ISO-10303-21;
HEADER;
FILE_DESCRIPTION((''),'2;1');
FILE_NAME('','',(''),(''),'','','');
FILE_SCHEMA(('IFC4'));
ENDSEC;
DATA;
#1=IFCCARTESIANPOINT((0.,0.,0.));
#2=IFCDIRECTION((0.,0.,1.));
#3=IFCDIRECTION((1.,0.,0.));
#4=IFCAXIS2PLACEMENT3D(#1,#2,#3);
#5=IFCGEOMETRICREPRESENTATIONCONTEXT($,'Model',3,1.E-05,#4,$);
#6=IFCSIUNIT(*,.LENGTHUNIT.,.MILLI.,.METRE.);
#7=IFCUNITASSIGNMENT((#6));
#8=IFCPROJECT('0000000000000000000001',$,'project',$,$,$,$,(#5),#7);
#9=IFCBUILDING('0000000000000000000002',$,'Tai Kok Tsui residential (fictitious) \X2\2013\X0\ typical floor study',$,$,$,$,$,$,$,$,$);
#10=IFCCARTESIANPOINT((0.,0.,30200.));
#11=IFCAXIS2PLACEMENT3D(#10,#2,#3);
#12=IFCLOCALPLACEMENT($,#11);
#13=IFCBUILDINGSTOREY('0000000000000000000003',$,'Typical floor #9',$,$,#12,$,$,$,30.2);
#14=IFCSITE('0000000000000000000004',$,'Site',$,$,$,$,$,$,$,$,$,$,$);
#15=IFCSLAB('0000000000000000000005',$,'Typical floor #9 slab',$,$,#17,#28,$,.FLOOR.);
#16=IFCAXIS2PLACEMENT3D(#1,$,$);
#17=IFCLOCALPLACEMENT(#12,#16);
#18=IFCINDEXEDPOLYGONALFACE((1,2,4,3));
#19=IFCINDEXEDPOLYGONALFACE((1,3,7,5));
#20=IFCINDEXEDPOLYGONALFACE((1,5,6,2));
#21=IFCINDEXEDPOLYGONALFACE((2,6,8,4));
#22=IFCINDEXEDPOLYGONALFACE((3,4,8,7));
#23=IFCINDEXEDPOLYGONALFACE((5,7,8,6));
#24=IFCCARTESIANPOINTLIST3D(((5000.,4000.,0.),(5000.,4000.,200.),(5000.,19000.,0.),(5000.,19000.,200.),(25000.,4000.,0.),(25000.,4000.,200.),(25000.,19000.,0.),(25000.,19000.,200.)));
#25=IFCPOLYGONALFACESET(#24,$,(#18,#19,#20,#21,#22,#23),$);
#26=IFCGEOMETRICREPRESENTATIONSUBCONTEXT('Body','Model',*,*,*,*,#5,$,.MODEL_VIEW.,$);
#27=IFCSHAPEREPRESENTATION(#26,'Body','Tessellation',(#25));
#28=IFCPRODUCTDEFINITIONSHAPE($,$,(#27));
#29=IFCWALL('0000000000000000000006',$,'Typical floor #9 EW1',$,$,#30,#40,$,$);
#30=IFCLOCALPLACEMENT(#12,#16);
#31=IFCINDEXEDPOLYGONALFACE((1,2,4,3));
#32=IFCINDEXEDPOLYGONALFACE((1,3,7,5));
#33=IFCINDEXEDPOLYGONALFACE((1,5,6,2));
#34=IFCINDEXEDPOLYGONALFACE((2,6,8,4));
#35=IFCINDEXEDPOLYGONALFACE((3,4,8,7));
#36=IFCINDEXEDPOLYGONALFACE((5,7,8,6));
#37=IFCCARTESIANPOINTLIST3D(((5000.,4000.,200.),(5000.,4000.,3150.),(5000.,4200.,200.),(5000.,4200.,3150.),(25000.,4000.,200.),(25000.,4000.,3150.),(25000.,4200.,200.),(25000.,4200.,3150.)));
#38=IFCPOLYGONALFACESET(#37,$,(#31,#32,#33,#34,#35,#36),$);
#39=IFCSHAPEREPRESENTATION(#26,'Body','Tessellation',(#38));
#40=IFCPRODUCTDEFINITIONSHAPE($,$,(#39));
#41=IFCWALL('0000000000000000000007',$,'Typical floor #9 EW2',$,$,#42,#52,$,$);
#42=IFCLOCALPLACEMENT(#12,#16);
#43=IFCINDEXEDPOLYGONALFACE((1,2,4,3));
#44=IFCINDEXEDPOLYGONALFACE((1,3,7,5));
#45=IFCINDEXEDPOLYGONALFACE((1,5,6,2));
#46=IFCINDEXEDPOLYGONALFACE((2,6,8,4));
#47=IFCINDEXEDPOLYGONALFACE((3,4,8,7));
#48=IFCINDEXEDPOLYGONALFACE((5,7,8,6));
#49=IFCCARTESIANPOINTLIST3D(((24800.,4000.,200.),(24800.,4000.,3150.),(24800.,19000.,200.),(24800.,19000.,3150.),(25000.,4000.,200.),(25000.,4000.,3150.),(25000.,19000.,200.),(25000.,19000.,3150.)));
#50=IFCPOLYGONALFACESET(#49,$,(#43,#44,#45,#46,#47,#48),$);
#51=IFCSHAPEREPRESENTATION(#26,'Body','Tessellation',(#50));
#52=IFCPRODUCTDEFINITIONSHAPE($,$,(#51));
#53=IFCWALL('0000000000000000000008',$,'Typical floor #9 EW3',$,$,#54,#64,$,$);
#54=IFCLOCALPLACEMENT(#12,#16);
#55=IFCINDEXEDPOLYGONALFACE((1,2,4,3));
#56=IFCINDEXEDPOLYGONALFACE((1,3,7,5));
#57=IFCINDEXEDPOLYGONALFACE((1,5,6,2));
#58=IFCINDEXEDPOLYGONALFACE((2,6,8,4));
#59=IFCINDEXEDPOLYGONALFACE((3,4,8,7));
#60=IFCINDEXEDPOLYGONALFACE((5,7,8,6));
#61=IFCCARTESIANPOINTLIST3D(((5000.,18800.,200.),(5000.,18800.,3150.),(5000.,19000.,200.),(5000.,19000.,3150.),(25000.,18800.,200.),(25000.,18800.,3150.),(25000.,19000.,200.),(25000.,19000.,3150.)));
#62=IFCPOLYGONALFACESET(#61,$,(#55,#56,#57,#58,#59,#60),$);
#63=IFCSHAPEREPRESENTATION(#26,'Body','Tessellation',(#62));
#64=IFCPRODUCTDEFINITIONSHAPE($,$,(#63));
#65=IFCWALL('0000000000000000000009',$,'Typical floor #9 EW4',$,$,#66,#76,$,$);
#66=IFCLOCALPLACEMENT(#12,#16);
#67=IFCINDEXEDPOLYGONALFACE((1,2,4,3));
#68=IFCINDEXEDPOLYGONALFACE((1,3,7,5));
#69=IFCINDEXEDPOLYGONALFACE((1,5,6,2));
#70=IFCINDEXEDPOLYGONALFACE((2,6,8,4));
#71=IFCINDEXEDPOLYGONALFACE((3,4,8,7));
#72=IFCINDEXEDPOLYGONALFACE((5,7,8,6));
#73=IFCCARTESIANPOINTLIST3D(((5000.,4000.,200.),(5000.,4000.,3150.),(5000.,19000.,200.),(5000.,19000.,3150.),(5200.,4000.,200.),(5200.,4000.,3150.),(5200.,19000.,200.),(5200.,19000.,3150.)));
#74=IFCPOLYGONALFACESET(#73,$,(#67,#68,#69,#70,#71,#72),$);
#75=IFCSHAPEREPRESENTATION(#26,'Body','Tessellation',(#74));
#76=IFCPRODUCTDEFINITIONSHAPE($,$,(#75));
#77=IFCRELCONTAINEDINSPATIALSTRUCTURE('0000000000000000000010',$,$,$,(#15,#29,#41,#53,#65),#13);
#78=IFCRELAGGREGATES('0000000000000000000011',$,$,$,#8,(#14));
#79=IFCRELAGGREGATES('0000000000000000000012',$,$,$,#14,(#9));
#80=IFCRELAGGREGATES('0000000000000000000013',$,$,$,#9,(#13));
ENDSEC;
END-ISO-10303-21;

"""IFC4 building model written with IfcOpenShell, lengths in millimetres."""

from ifc_helpers import new_model, si_unit, frame, origin_with_axes, place, context, subcontext, project, spatial, indexed_curve, outline, extrude, element, save


model = new_model("IFC4")

# Units and contexts
model_context = context("Model", 3, precision=1e-05, world=origin_with_axes())
body_context = subcontext(model_context, "Body", "Model", "MODEL_VIEW")
ifc_project = project(units=[si_unit("LENGTHUNIT", "METRE", prefix="MILLI")], contexts=[model_context])

# Site, building, storey
site = spatial("IfcSite", under=ifc_project, Name="Site")
building = spatial("IfcBuilding", under=site, Name="Tai Kok Tsui residential (fictitious) – typical floor study")
storey_placement = place(None, frame((0.0, 0.0, 30200.0), z_axis=(0.0, 0.0, 1.0), x_axis=(1.0, 0.0, 0.0)))
storey = spatial("IfcBuildingStorey", under=building, at=storey_placement, Name="Typical floor #9", Elevation=30.2)

# Slab
slab_placement = place(storey_placement, origin_with_axes())
element("IfcSlab", 1, at=slab_placement, inside=storey, Name="Typical floor #9 slab", PredefinedType="FLOOR", context=body_context, shape_type="SweptSolid", body=[
    extrude(outline(indexed_curve([(5000.0, 4000.0), (25000.0, 4000.0), (25000.0, 19000.0), (5000.0, 19000.0)])), None, (0.0, 0.0, 1.0), 200.0),
])

# Walls
wall_1_placement = place(storey_placement, frame((5000.0, 4000.0, 200.0), z_axis=(0.0, 0.0, 1.0), x_axis=(1.0, 0.0, 0.0)))
element("IfcWall", 2, at=wall_1_placement, inside=storey, Name="Typical floor #9 EW1", context=body_context, shape_type="SweptSolid", body=[
    extrude(outline(indexed_curve([(0.0, 0.0), (0.0, 200.0), (20000.0, 200.0), (20000.0, 0.0), (0.0, 0.0)], self_intersect=False)), origin_with_axes(), (0.0, 0.0, 1.0), 2950.0),
])
wall_2_placement = place(storey_placement, frame((25000.0, 4000.0, 200.0), z_axis=(0.0, 0.0, 1.0), x_axis=(0.0, 1.0, 0.0)))
element("IfcWall", 3, at=wall_2_placement, inside=storey, Name="Typical floor #9 EW2", context=body_context, shape_type="SweptSolid", body=[
    extrude(outline(indexed_curve([(0.0, 0.0), (0.0, 200.0), (15000.0, 200.0), (15000.0, 0.0), (0.0, 0.0)], self_intersect=False)), origin_with_axes(), (0.0, 0.0, 1.0), 2950.0),
])
wall_3_placement = place(storey_placement, frame((25000.0, 19000.0, 200.0), z_axis=(0.0, 0.0, 1.0), x_axis=(-1.0, 0.0, 0.0)))
element("IfcWall", 4, at=wall_3_placement, inside=storey, Name="Typical floor #9 EW3", context=body_context, shape_type="SweptSolid", body=[
    extrude(outline(indexed_curve([(0.0, 0.0), (0.0, 200.0), (20000.0, 200.0), (20000.0, 0.0), (0.0, 0.0)], self_intersect=False)), origin_with_axes(), (0.0, 0.0, 1.0), 2950.0),
])
wall_4_placement = place(storey_placement, frame((5000.0, 19000.0, 200.0), z_axis=(0.0, 0.0, 1.0), x_axis=(0.0, -1.0, 0.0)))
element("IfcWall", 5, at=wall_4_placement, inside=storey, Name="Typical floor #9 EW4", context=body_context, shape_type="SweptSolid", body=[
    extrude(outline(indexed_curve([(0.0, 0.0), (0.0, 200.0), (15000.0, 200.0), (15000.0, 0.0), (0.0, 0.0)], self_intersect=False)), origin_with_axes(), (0.0, 0.0, 1.0), 2950.0),
])

save(model, "model.ifc")
